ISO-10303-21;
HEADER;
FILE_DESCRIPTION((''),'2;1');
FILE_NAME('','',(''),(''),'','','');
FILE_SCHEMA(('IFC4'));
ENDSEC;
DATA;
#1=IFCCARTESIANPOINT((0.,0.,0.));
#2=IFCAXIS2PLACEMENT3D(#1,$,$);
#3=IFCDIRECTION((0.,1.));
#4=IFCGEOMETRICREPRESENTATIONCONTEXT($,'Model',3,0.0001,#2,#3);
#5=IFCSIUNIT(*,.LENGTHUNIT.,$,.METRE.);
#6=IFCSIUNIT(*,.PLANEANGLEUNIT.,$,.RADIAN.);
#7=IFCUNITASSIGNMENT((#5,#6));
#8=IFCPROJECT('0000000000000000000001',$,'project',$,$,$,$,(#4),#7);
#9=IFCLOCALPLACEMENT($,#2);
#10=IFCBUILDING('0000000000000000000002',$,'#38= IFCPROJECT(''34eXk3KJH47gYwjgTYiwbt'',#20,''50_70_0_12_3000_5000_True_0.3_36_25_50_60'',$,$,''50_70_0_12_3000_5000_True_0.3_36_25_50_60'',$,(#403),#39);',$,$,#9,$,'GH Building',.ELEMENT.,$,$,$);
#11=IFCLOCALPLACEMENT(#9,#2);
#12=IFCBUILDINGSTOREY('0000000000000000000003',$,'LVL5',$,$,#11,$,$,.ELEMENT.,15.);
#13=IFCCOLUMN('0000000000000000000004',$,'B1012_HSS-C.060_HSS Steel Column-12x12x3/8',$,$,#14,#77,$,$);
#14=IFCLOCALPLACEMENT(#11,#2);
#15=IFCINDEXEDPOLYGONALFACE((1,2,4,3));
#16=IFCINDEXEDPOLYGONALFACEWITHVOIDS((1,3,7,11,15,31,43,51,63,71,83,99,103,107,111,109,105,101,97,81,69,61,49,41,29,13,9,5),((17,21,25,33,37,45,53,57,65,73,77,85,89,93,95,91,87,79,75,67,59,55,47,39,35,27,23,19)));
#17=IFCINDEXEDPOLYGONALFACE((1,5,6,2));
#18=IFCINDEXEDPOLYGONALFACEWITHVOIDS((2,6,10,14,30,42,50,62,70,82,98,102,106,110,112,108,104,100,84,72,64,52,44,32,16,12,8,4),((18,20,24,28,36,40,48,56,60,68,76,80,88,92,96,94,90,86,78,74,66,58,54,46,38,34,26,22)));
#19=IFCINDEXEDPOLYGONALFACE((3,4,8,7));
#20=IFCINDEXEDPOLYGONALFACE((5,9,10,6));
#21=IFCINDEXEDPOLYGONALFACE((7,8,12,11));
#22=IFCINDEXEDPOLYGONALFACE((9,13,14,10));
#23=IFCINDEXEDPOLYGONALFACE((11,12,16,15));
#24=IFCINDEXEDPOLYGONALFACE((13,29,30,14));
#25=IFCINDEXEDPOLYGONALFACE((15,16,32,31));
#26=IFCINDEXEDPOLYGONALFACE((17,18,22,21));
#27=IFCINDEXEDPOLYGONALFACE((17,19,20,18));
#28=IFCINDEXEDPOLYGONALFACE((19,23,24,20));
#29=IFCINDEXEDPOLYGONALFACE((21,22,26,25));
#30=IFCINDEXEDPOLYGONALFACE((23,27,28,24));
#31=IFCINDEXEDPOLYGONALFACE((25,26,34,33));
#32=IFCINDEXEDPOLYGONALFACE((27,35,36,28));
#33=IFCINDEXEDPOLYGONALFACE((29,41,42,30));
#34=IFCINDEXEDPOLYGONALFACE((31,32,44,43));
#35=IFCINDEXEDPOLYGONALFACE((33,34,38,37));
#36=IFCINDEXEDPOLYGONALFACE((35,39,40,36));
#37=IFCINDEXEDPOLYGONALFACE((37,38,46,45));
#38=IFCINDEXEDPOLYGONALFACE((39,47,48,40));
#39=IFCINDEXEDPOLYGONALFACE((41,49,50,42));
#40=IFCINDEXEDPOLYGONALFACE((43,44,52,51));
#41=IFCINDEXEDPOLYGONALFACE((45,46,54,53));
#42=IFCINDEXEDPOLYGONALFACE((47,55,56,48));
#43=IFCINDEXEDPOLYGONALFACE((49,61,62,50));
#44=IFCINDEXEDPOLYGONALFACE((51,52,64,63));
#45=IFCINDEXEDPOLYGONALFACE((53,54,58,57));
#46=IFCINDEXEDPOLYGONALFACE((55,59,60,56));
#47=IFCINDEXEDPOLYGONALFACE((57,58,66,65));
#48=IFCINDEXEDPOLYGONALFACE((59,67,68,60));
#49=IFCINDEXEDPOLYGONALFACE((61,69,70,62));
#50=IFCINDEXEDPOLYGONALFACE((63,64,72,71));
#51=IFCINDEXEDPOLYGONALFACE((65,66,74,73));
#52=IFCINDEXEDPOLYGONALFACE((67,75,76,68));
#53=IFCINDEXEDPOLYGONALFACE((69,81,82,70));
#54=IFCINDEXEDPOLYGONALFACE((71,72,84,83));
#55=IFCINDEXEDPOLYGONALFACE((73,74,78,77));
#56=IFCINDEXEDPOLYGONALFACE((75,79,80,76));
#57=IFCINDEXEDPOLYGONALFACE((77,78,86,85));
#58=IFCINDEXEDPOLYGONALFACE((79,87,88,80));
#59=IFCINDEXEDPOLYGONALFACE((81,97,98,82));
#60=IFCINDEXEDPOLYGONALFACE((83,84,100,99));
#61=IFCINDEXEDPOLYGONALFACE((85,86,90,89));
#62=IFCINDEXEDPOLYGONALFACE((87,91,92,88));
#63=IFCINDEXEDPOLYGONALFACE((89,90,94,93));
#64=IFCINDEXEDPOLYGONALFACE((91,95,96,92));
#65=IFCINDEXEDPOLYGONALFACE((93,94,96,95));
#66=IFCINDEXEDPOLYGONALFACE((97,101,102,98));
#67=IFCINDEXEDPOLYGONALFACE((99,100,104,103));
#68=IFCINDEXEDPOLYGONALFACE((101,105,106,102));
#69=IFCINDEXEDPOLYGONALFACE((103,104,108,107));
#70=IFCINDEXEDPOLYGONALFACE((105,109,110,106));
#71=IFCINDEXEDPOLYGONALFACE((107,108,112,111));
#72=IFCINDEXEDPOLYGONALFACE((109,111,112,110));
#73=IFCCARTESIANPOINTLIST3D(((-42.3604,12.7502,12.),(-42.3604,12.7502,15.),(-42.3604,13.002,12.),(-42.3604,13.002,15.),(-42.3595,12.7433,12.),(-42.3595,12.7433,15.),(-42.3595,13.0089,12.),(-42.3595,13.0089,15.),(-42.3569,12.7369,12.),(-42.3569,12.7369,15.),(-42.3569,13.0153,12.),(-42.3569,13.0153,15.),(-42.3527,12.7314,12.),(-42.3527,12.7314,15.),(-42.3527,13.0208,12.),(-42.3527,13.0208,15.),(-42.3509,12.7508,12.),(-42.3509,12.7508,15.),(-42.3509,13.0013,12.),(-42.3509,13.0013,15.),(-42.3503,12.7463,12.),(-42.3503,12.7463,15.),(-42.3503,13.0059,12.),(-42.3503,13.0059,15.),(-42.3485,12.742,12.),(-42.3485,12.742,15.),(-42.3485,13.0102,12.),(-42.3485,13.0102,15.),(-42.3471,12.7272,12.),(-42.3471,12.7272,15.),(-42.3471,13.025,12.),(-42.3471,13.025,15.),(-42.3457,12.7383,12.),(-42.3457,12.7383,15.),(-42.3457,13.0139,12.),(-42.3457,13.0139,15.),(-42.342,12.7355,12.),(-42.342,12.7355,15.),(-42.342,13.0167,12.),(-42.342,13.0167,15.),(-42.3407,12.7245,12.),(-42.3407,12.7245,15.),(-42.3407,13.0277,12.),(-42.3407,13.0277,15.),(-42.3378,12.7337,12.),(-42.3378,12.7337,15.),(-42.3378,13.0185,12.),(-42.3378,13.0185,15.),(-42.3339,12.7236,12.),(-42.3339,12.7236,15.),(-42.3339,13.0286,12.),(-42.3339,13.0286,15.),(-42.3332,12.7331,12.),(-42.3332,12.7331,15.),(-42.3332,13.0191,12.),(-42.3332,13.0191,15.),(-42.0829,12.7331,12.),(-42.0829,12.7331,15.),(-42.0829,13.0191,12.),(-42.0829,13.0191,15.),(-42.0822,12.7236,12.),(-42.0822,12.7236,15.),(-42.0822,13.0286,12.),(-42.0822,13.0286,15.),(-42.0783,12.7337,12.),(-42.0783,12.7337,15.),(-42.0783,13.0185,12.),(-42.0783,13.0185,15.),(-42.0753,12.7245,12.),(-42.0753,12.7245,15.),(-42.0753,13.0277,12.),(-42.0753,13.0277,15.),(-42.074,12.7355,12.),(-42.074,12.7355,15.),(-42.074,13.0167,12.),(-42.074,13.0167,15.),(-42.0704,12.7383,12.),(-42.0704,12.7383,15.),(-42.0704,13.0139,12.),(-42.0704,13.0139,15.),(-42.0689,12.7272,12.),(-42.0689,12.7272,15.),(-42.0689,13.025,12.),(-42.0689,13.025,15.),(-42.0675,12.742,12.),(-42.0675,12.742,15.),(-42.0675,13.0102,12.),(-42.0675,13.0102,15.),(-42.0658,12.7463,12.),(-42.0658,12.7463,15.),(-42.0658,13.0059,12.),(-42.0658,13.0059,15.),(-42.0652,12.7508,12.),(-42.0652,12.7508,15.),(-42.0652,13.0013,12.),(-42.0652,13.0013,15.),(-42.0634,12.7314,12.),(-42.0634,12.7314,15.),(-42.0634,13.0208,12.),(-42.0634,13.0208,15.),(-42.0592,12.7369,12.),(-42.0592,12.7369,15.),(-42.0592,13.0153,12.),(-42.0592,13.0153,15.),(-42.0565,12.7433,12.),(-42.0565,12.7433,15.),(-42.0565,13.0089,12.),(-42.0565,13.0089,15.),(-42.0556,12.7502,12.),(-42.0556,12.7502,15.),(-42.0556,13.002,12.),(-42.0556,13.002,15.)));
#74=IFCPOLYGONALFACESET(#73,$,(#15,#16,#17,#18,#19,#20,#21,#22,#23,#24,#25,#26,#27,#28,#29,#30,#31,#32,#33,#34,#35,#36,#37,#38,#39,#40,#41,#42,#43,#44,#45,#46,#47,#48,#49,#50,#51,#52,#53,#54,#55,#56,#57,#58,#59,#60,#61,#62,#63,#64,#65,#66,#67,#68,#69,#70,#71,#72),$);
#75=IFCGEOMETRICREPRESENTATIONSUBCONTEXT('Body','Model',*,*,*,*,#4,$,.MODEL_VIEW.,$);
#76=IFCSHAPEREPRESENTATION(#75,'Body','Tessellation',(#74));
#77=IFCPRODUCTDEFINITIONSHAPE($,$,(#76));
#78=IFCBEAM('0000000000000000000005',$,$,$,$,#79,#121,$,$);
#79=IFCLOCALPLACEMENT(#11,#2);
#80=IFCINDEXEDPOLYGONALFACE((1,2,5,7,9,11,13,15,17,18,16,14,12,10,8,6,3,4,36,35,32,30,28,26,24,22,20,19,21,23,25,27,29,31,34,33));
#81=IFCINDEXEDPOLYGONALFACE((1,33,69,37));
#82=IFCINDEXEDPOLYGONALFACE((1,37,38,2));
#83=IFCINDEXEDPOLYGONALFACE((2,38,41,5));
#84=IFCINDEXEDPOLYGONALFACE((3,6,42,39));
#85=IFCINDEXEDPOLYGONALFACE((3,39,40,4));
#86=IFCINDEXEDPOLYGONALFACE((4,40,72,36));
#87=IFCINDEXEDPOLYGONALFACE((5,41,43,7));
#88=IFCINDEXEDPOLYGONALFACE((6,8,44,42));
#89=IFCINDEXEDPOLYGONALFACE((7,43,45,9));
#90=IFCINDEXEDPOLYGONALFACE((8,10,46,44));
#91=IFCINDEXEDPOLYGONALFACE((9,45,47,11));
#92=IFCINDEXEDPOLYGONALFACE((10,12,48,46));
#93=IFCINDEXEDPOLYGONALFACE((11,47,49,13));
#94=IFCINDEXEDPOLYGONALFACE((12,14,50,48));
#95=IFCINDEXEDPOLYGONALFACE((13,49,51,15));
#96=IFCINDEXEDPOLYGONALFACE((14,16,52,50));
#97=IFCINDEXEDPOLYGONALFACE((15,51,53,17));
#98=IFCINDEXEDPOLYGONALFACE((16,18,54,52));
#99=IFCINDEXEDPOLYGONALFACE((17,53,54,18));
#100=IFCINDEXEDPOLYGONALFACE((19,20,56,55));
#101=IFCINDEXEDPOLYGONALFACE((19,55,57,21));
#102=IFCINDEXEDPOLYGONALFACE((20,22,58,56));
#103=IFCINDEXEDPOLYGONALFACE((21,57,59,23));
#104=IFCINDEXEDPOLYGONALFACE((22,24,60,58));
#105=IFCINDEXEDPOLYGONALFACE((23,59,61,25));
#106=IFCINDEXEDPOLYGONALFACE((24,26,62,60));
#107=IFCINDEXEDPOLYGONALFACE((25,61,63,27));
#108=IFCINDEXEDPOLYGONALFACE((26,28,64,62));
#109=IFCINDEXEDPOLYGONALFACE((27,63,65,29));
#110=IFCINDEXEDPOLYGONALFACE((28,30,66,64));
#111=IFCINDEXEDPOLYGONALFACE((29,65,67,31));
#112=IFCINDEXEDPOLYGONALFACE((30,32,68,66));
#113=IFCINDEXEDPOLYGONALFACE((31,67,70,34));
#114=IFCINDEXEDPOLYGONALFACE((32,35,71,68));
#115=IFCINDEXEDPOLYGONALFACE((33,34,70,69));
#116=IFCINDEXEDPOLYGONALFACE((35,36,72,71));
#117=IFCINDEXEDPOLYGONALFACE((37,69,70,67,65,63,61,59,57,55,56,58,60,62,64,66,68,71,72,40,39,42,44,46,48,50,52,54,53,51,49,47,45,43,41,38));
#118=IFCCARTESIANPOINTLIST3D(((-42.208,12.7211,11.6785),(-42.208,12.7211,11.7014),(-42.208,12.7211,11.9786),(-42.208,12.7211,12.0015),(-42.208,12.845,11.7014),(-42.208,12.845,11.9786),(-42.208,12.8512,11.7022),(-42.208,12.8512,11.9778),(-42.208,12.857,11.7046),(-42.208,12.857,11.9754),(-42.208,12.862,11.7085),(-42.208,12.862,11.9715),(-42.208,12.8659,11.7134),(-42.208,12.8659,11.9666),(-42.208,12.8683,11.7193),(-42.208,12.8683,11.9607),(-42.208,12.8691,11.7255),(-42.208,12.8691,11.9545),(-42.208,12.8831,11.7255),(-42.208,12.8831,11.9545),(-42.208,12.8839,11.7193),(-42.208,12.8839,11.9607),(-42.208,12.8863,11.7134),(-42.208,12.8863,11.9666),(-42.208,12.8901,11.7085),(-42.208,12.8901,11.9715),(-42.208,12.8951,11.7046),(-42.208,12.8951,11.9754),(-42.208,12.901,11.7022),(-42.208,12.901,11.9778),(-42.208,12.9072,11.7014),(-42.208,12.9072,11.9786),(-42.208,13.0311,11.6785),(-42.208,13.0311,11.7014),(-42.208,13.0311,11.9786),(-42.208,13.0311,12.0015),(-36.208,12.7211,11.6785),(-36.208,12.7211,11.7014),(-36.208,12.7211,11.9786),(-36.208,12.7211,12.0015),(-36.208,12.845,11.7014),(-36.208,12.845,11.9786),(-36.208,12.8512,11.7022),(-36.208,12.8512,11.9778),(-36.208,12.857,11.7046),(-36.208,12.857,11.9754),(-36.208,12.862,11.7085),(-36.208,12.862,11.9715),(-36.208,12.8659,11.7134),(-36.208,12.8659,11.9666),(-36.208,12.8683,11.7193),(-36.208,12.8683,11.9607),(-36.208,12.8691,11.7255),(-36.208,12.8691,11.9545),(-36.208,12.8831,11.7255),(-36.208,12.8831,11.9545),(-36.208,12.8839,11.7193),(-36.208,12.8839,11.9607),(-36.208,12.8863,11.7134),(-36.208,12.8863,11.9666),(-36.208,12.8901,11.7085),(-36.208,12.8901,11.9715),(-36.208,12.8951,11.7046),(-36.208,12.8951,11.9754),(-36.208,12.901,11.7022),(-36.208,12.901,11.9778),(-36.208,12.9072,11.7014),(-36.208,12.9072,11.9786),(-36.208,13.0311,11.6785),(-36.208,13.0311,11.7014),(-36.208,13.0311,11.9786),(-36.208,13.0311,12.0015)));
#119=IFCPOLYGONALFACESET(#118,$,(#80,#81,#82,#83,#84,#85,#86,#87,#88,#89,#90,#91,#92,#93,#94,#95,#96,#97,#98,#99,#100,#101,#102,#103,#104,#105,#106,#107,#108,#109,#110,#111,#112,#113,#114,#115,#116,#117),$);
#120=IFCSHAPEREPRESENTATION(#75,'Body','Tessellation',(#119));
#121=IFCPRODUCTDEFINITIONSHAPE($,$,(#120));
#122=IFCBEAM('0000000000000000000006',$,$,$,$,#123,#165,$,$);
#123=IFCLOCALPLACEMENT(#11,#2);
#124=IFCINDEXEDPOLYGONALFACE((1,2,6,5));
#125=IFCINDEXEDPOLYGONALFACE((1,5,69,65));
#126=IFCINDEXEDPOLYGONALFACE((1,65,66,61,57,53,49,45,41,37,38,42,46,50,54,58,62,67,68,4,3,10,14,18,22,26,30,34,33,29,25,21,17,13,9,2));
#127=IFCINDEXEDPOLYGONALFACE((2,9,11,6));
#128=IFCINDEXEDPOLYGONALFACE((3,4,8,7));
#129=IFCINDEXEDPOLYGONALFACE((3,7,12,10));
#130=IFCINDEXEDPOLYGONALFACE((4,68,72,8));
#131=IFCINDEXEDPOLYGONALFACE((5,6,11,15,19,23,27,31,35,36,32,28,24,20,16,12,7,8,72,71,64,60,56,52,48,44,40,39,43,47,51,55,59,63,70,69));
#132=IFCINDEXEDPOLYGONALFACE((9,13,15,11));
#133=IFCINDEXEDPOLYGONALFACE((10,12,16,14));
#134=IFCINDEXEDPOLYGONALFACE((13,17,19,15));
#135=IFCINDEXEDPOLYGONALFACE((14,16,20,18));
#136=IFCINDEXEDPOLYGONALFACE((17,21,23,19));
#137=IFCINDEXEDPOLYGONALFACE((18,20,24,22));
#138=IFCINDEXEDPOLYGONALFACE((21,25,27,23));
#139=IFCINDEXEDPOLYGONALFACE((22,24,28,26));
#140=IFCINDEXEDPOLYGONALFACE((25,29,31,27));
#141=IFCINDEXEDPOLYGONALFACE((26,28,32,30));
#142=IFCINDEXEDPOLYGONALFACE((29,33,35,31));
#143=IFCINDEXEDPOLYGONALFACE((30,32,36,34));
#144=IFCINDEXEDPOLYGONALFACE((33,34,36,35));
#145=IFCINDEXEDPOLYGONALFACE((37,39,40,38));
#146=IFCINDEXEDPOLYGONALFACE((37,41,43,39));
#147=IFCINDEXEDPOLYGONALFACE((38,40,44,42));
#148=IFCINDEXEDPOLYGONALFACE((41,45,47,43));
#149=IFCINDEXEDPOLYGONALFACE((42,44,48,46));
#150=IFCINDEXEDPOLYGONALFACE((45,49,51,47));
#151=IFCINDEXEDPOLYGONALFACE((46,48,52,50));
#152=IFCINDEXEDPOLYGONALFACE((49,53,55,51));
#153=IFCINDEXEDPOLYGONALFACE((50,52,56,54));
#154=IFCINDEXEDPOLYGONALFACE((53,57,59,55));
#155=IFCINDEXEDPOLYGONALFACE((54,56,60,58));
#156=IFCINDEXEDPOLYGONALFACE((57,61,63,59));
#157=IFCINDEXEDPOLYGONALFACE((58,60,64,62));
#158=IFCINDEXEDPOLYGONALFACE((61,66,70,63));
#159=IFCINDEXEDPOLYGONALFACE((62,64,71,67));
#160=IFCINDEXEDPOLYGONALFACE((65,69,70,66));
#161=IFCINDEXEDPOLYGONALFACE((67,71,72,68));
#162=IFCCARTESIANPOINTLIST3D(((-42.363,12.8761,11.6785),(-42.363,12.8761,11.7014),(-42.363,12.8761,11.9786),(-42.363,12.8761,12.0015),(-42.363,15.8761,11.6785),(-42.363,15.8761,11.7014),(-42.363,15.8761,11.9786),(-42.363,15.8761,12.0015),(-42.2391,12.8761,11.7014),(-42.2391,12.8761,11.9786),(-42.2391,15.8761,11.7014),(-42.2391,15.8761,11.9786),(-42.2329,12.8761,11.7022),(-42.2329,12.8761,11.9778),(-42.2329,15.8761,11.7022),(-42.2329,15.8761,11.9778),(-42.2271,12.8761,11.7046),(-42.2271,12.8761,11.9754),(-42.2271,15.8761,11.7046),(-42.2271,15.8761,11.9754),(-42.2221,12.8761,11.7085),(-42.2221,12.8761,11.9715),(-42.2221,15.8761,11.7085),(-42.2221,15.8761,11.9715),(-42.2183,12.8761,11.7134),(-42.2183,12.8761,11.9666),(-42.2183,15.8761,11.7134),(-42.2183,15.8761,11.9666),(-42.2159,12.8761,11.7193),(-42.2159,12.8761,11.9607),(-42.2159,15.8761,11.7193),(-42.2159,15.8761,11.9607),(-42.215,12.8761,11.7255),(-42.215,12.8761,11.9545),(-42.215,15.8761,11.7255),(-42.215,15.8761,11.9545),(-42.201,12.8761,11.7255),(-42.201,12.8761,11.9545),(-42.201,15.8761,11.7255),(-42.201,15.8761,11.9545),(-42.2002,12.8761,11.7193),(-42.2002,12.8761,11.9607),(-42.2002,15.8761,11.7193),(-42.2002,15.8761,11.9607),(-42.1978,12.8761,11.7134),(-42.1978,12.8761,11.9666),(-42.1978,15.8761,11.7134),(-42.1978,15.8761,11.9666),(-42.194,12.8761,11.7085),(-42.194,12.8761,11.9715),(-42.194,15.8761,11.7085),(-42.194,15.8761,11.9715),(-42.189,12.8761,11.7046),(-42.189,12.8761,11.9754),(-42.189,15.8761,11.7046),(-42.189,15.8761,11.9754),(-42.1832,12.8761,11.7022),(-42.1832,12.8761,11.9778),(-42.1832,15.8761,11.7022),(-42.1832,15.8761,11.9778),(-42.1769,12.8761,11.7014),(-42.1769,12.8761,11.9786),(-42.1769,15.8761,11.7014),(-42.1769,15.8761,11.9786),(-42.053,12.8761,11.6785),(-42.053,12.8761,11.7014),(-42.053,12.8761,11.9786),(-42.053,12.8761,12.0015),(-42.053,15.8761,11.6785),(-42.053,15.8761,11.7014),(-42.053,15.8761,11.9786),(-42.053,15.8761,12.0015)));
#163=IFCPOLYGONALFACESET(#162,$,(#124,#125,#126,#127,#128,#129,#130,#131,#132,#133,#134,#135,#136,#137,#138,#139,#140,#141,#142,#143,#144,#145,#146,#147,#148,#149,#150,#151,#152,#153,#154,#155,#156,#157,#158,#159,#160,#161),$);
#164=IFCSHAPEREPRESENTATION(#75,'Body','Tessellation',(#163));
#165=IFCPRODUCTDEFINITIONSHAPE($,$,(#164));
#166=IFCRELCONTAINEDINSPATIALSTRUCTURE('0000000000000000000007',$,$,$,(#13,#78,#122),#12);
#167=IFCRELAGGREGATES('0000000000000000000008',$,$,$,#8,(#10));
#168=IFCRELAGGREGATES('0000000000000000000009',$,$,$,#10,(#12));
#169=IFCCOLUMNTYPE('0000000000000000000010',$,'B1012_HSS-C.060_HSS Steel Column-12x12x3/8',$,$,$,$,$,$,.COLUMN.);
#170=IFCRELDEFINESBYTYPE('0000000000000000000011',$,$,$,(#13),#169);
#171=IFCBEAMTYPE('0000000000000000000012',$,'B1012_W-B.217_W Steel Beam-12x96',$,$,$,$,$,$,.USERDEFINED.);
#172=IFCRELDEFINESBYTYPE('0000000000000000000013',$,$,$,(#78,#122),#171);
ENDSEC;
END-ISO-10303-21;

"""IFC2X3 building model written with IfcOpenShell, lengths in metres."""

from ifc_helpers import new_model, si_unit, direction, frame, origin, origin_2d, place, context, subcontext, project, spatial, hollow_rectangle, i_section, extrude, type_object, element, save


model = new_model("IFC2X3")

# Units and contexts
model_context = context("Model", 3, precision=0.0001, world=origin(), true_north=direction((0.0, 1.0)))
body_context = subcontext(model_context, "Body", "Model", "MODEL_VIEW")
ifc_project = project(units=[si_unit("LENGTHUNIT", "METRE"), si_unit("PLANEANGLEUNIT", "RADIAN")], contexts=[model_context])

# Building, storey
building_placement = place(None, origin())
building = spatial("IfcBuilding", under=ifc_project, at=building_placement, Name="#38= IFCPROJECT('34eXk3KJH47gYwjgTYiwbt',#20,'50_70_0_12_3000_5000_True_0.3_36_25_50_60',$,$,'50_70_0_12_3000_5000_True_0.3_36_25_50_60',$,(#403),#39);", LongName="GH Building", CompositionType="ELEMENT")
storey_placement = place(building_placement, origin())
storey = spatial("IfcBuildingStorey", under=building, at=storey_placement, Name="LVL5", CompositionType="ELEMENT", Elevation=15.0)

# Column
column_type_1 = type_object("IfcColumnType", Name="B1012_HSS-C.060_HSS Steel Column-12x12x3/8", PredefinedType="COLUMN")
for number, where, z_axis, x_axis, name in (
    (1, (-42.208, 12.8761, 15.0), (0.0, 0.0, -1.0), (-1.0, 0.0, 0.0), "B1012_HSS-C.060_HSS Steel Column-12x12x3/8"),
):
    element("IfcColumn", number, at=place(storey_placement, frame(where, z_axis=z_axis, x_axis=x_axis)), inside=storey, type_object=column_type_1, Name=name, context=body_context, shape_type="SweptSolid", body=[
        extrude(hollow_rectangle(XDim=0.3048, YDim=0.305, WallThickness=0.0095, InnerFilletRadius=0.0177, OuterFilletRadius=0.0266, at=origin_2d()), origin(), (0.0, 0.0, 1.0), 3.0),
    ])

# Beams
beam_type = type_object("IfcBeamType", Name="B1012_W-B.217_W Steel Beam-12x96", PredefinedType="USERDEFINED")
beam_1_placement = place(storey_placement, frame((-42.208, 12.8761, 11.84), z_axis=(1.0, 0.0, 0.0), x_axis=(0.0, 1.0, 0.0)))
element("IfcBeam", 2, at=beam_1_placement, inside=storey, type_object=beam_type, context=body_context, shape_type="SweptSolid", body=[
    extrude(i_section(OverallWidth=0.31, OverallDepth=0.323, WebThickness=0.014, FlangeThickness=0.0229, FilletRadius=0.0241, at=origin_2d()), origin(), (0.0, 0.0, 1.0), 6.0),
])
beam_2_placement = place(storey_placement, frame((-42.208, 12.8761, 11.84), z_axis=(0.0, 1.0, 0.0), x_axis=(-1.0, 0.0, 0.0)))
element("IfcBeam", 3, at=beam_2_placement, inside=storey, type_object=beam_type, context=body_context, shape_type="SweptSolid", body=[
    extrude(i_section(OverallWidth=0.31, OverallDepth=0.323, WebThickness=0.014, FlangeThickness=0.0229, FilletRadius=0.0241, at=origin_2d()), origin(), (0.0, 0.0, 1.0), 3.0),
])

save(model, "model.ifc")
